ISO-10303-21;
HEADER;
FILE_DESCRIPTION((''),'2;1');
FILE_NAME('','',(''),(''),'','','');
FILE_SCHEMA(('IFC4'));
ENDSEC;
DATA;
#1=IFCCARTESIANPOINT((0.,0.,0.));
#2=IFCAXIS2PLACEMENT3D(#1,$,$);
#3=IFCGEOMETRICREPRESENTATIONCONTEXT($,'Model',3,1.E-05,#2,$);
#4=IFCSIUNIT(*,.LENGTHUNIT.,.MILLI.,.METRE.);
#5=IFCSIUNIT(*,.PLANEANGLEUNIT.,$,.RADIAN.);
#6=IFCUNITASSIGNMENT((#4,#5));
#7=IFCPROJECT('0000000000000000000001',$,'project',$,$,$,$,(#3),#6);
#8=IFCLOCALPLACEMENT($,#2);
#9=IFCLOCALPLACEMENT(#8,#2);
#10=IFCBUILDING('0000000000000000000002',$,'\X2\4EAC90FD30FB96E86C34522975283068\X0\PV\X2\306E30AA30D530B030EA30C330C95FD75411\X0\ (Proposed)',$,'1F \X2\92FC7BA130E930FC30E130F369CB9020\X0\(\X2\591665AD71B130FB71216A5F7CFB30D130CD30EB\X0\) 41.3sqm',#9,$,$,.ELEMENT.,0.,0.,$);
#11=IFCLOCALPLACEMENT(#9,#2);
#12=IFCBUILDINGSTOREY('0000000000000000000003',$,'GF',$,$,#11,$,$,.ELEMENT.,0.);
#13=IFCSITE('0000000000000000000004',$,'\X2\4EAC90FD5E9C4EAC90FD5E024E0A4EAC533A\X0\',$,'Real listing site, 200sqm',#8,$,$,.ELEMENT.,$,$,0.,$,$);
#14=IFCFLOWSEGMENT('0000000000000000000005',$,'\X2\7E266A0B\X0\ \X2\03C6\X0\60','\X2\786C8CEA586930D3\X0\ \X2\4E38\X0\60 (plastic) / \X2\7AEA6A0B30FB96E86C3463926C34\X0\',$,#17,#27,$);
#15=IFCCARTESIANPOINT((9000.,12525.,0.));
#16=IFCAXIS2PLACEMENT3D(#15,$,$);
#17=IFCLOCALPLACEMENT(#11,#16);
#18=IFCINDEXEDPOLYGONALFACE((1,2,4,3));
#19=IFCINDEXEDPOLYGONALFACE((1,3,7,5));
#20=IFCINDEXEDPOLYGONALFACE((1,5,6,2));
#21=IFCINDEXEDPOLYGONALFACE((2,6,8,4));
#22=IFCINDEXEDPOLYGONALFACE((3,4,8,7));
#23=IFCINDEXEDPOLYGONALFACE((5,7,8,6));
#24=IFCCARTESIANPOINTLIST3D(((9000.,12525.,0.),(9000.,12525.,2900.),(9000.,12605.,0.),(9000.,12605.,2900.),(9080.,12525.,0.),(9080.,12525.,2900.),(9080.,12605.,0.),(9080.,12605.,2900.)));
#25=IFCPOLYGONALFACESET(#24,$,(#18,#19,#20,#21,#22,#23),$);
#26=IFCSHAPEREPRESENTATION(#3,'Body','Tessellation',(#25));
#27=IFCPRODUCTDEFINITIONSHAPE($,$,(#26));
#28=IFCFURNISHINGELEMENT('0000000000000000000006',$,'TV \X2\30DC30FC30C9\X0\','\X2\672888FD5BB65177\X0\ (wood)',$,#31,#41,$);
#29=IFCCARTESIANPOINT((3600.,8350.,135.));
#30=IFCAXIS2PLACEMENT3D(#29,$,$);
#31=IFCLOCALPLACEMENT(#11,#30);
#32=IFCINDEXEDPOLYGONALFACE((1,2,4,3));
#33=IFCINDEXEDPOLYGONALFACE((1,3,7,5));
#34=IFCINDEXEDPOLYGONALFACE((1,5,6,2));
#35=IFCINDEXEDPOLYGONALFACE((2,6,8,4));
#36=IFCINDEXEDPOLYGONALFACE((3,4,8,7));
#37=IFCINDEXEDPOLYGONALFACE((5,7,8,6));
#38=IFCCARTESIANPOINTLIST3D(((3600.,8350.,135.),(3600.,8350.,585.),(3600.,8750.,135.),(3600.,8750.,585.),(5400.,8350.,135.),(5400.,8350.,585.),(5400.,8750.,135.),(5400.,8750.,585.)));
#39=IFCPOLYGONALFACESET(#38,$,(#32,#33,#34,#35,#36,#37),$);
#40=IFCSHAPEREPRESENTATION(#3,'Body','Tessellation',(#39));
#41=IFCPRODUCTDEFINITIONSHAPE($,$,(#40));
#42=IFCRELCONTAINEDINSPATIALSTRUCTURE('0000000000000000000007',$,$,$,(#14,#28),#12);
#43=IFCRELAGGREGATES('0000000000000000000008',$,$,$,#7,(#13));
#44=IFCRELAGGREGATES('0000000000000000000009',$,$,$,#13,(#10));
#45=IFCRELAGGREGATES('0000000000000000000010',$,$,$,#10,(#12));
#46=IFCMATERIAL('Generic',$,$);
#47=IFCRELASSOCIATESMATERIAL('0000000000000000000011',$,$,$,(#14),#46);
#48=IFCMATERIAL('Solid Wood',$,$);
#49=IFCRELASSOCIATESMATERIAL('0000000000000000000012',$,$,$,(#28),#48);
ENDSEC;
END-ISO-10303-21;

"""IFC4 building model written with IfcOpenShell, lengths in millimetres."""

from ifc_helpers import new_model, si_unit, frame, frame_2d, origin, place, context, project, spatial, rectangle, extrude, material, element, save


model = new_model("IFC4")

# Units and contexts
model_context = context("Model", 3, precision=1e-05, world=origin())
ifc_project = project(units=[si_unit("LENGTHUNIT", "METRE", prefix="MILLI"), si_unit("PLANEANGLEUNIT", "RADIAN")], contexts=[model_context])

# Site, building, storey
site_placement = place(None, origin())
site = spatial("IfcSite", under=ifc_project, at=site_placement, Name="京都府京都市上京区", ObjectType="Real listing site, 200sqm", CompositionType="ELEMENT", RefElevation=0.0)
building_placement = place(site_placement, origin())
building = spatial("IfcBuilding", under=site, at=building_placement, Name="京都・雨水利用とPVのオフグリッド志向 (Proposed)", ObjectType="1F 鋼管ラーメン構造(外断熱・無機系パネル) 41.3sqm", CompositionType="ELEMENT", ElevationOfRefHeight=0.0, ElevationOfTerrain=0.0)
storey_placement = place(building_placement, origin())
storey = spatial("IfcBuildingStorey", under=building, at=storey_placement, Name="GF", CompositionType="ELEMENT", Elevation=0.0)

# Shared definitions
ifc_material_1 = material(Name="Solid Wood")

# Shared definitions
ifc_material_2 = material(Name="Generic")

# Flow segment
flow_segment_placement = place(storey_placement, frame((9000.0, 12525.0, 0.0)))
element("IfcFlowSegment", 1, at=flow_segment_placement, inside=storey, material=ifc_material_2, Name="縦樋 φ60", Description="硬質塩ビ 丸60 (plastic) / 竪樋・雨水排水", context=model_context, shape_type="SweptSolid", body=[
    extrude(rectangle(XDim=80.0, YDim=80.0, at=frame_2d((40.0, 40.0))), frame((9000.0, 12525.0, 0.0)), (0.0, 0.0, 1.0), 2900.0),
])

# Furnishing element
furnishing_placement = place(storey_placement, frame((3600.0, 8350.0, 135.0)))
element("IfcFurnishingElement", 2, at=furnishing_placement, inside=storey, material=ifc_material_1, Name="TV ボード", Description="木製家具 (wood)", context=model_context, shape_type="SweptSolid", body=[
    extrude(rectangle(XDim=1800.0, YDim=400.0, at=frame_2d((900.0, 200.0))), frame((3600.0, 8350.0, 135.0)), (0.0, 0.0, 1.0), 450.0),
])

save(model, "model.ifc")
